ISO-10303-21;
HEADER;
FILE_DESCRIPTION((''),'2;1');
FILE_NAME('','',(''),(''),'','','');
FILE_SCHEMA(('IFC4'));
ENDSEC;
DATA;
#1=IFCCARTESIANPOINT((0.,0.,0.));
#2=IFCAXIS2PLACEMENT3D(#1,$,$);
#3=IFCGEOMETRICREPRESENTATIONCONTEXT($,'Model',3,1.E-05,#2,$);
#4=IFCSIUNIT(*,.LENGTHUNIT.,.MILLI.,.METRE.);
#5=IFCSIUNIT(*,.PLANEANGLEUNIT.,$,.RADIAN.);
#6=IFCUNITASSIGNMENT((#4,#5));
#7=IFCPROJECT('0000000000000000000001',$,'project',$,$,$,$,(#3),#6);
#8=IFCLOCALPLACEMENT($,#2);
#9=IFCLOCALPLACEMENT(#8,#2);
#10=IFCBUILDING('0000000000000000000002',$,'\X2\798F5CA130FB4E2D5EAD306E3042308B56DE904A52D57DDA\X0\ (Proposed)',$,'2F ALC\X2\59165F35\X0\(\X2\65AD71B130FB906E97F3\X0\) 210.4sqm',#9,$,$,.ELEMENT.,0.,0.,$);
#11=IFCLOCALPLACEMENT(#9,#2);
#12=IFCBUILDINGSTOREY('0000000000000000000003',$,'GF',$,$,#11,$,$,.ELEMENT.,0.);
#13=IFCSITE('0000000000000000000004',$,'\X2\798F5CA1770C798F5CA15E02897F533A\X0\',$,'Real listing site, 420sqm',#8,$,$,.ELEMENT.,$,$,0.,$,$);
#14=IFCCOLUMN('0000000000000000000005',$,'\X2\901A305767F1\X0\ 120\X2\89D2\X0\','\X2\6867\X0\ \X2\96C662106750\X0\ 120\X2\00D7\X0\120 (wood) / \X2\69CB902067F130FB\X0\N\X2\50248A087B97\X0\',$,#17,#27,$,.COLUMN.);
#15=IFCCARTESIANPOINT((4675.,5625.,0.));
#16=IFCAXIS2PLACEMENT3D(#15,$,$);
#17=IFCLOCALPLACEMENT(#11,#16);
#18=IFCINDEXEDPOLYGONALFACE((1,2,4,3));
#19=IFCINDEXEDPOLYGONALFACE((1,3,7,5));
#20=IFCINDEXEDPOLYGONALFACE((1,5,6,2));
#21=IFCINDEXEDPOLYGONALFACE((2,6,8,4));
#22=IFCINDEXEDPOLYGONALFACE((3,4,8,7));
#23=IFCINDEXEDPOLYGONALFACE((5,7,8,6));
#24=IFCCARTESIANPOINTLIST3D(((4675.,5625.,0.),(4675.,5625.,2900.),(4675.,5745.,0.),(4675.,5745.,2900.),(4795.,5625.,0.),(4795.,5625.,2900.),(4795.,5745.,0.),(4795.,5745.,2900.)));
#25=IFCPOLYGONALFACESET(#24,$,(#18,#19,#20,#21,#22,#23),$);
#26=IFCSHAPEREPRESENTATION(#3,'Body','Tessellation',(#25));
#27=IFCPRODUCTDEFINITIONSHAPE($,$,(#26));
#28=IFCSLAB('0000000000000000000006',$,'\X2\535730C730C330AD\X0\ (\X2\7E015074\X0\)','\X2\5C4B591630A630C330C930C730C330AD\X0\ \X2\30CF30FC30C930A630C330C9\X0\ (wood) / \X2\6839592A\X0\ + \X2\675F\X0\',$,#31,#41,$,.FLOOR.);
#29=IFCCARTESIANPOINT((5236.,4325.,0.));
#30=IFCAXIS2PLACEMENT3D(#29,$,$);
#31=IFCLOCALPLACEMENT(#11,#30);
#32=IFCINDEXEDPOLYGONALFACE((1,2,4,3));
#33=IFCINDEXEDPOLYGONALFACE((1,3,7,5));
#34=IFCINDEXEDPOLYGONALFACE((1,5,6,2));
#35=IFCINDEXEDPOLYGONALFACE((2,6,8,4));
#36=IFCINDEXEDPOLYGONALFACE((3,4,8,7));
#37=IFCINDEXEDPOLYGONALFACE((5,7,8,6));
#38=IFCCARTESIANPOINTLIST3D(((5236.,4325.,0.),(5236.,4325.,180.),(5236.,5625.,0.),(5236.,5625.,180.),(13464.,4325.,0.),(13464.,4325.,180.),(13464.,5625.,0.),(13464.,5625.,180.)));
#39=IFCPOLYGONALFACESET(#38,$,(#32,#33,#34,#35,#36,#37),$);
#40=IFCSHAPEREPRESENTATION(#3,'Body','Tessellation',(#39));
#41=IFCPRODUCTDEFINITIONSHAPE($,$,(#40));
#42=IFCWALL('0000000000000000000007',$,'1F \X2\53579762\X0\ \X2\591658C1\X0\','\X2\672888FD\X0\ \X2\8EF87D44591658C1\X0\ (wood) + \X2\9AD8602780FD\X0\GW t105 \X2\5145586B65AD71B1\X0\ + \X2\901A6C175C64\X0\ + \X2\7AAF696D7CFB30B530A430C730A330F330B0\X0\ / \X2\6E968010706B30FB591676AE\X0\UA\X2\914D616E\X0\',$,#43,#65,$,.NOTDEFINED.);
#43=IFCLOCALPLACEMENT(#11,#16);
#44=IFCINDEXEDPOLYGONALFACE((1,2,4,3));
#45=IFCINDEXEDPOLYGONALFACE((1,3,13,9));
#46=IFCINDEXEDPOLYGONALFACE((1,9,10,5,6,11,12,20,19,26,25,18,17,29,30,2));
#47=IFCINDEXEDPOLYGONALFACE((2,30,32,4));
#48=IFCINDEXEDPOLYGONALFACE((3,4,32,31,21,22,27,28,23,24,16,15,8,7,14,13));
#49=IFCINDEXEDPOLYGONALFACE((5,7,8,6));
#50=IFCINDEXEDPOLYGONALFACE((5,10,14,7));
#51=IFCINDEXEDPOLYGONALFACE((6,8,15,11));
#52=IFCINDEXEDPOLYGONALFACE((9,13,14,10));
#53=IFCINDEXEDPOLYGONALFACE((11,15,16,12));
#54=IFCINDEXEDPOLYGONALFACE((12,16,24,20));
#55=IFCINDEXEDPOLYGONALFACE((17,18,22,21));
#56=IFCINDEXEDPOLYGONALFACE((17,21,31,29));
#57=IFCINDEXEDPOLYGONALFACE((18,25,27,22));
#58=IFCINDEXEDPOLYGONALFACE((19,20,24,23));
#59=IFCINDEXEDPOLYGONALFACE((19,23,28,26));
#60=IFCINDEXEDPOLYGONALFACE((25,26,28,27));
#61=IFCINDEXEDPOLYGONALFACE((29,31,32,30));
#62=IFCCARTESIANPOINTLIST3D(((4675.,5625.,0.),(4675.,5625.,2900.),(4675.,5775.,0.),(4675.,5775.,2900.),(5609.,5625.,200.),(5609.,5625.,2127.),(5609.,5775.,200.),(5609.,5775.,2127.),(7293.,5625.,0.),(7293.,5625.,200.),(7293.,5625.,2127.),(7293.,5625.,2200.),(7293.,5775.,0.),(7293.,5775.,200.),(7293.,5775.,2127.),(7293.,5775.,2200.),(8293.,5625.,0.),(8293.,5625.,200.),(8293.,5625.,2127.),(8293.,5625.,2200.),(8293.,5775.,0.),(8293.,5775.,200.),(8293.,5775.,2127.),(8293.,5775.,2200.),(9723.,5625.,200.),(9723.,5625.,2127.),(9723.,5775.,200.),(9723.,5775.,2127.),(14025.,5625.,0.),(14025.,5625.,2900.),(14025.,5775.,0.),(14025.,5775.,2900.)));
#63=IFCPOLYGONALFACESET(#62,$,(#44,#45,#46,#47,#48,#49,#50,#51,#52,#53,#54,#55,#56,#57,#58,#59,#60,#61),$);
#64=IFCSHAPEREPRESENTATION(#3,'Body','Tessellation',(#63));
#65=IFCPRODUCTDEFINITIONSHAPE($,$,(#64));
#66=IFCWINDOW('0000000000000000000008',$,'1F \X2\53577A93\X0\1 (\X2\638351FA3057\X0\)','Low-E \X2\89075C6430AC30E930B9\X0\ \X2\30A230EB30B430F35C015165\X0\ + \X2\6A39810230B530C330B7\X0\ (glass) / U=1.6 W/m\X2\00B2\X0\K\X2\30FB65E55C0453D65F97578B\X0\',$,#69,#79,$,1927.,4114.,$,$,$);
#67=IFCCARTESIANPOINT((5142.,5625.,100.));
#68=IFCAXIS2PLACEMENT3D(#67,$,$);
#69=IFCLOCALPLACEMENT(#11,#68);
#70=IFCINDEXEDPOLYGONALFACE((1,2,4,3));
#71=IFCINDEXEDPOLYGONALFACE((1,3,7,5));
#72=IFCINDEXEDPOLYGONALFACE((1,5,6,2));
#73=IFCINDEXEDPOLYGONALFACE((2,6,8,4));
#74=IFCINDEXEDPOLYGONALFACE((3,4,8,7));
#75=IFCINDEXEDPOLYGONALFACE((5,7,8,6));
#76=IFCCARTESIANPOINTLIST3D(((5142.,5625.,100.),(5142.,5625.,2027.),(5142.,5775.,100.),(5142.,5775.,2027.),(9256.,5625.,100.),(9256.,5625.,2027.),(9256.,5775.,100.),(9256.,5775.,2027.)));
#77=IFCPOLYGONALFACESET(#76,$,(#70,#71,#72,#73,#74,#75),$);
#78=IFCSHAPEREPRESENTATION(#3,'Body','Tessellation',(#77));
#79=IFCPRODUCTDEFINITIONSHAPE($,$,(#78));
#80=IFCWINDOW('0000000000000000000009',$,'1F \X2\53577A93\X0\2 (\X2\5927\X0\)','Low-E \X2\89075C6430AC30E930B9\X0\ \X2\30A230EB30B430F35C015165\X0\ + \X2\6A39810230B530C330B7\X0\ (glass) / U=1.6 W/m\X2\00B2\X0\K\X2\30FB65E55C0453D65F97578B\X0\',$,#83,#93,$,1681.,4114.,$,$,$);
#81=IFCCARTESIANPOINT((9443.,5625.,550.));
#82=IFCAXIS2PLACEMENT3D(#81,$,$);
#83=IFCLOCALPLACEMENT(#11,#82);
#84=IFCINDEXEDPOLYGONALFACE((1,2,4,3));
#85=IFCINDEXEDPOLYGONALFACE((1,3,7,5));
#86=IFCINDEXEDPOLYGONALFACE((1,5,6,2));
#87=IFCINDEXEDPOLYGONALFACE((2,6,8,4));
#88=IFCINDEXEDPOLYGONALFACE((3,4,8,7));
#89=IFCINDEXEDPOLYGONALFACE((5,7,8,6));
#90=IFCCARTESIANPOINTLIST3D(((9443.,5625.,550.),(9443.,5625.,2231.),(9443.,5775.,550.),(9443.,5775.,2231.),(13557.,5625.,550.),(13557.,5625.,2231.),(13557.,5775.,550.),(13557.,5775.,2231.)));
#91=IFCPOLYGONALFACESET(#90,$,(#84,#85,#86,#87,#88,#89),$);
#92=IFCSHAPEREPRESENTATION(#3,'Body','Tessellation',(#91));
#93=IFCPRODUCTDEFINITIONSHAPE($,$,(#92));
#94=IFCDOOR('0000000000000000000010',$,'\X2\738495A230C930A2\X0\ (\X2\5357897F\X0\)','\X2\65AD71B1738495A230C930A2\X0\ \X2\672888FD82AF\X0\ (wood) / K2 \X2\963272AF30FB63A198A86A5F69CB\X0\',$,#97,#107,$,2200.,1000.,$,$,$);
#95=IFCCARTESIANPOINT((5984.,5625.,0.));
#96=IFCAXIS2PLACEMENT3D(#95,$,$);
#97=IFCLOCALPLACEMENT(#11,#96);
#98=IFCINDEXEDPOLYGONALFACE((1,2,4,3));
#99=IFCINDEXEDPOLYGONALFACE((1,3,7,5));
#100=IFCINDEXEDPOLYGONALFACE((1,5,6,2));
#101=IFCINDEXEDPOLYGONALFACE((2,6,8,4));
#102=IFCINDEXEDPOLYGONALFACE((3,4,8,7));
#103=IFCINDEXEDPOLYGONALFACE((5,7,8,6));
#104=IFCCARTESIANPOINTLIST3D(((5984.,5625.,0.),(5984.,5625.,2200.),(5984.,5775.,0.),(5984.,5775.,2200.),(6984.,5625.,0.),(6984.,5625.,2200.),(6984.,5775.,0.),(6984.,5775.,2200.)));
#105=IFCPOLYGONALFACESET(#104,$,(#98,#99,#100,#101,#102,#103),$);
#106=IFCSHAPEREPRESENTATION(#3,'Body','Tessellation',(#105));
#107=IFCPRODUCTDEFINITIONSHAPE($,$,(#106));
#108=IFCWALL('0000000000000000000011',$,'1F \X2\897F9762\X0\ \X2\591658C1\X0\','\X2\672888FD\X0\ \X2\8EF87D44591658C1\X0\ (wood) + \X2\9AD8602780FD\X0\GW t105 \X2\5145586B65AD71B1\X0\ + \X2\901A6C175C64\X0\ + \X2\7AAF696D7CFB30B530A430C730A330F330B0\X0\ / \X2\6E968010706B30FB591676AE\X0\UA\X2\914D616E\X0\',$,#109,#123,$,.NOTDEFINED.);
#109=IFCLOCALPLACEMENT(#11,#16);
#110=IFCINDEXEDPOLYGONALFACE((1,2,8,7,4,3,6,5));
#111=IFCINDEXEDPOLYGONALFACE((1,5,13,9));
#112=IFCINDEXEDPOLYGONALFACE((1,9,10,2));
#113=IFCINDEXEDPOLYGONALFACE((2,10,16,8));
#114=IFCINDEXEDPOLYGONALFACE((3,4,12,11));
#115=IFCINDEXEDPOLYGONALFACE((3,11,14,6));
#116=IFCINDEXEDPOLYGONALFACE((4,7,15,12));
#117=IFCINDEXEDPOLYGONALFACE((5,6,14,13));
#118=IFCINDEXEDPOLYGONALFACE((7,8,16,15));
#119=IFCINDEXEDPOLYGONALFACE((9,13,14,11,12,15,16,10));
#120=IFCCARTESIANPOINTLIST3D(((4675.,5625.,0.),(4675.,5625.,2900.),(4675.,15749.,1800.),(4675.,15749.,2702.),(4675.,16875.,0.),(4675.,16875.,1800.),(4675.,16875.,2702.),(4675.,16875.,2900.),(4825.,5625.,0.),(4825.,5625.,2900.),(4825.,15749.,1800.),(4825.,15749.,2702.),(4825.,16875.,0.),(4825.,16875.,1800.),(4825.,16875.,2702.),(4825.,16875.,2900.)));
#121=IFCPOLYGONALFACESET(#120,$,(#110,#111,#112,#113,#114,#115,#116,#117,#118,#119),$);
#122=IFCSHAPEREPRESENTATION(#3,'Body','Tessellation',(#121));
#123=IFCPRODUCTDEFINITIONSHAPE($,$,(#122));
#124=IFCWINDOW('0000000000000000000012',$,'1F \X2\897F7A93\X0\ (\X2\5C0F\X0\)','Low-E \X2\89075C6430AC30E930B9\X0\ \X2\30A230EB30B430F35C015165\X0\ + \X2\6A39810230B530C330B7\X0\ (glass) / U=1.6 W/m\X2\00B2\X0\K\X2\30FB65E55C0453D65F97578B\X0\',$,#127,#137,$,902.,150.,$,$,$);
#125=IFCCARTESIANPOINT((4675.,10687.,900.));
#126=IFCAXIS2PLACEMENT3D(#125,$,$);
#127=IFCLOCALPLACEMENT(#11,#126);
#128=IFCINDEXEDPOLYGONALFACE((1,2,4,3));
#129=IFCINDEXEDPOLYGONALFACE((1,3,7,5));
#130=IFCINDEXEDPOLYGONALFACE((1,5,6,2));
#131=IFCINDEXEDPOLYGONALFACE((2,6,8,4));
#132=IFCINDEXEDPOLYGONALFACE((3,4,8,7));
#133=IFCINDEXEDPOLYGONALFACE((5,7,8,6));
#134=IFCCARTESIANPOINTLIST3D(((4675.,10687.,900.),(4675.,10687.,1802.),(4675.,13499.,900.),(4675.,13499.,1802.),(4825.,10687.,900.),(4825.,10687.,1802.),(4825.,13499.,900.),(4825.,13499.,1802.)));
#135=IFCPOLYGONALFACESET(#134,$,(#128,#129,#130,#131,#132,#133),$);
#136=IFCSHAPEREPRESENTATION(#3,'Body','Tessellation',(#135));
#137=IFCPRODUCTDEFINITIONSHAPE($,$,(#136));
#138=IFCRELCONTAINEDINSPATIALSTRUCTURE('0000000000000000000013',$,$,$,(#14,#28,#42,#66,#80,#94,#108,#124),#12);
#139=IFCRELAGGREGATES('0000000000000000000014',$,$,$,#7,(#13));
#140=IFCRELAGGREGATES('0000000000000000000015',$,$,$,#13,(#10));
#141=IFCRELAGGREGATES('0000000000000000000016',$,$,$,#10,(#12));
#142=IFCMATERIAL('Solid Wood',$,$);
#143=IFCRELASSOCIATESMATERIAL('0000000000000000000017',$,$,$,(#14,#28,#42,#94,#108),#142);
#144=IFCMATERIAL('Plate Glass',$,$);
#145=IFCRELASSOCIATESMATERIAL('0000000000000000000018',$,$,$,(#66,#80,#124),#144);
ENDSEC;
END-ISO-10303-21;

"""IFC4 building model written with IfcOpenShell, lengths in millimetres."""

from ifc_helpers import new_model, si_unit, frame, frame_2d, origin, place, context, project, spatial, rectangle, extrude, material, element, fill, save


model = new_model("IFC4")

# Units and contexts
model_context = context("Model", 3, precision=1e-05, world=origin())
ifc_project = project(units=[si_unit("LENGTHUNIT", "METRE", prefix="MILLI"), si_unit("PLANEANGLEUNIT", "RADIAN")], contexts=[model_context])

# Site, building, storey
site_placement = place(None, origin())
site = spatial("IfcSite", under=ifc_project, at=site_placement, Name="福岡県福岡市西区", ObjectType="Real listing site, 420sqm", CompositionType="ELEMENT", RefElevation=0.0)
building_placement = place(site_placement, origin())
building = spatial("IfcBuilding", under=site, at=building_placement, Name="福岡・中庭のある回遊動線 (Proposed)", ObjectType="2F ALC外張(断熱・遮音) 210.4sqm", CompositionType="ELEMENT", ElevationOfRefHeight=0.0, ElevationOfTerrain=0.0)
storey_placement = place(building_placement, origin())
storey = spatial("IfcBuildingStorey", under=building, at=storey_placement, Name="GF", CompositionType="ELEMENT", Elevation=0.0)

# Column
ifc_material_1 = material(Name="Solid Wood")
column_placement = place(storey_placement, frame((4675.0, 5625.0, 0.0)))
element("IfcColumn", 1, at=column_placement, inside=storey, material=ifc_material_1, Name="通し柱 120角", Description="桧 集成材 120×120 (wood) / 構造柱・N値計算", PredefinedType="COLUMN", context=model_context, shape_type="SweptSolid", body=[
    extrude(rectangle(XDim=120.0, YDim=120.0, at=frame_2d((60.0, 60.0))), frame((4675.0, 5625.0, 0.0)), (0.0, 0.0, 1.0), 2900.0),
])

# Slab
slab_1_placement = place(storey_placement, frame((5236.0, 4325.0, 0.0)))
element("IfcSlab", 2, at=slab_1_placement, inside=storey, material=ifc_material_1, Name="南デッキ (縁側)", Description="屋外ウッドデッキ ハードウッド (wood) / 根太 + 束", PredefinedType="FLOOR", context=model_context, shape_type="SweptSolid", body=[
    extrude(rectangle(XDim=8228.0, YDim=1300.0, at=frame_2d((4114.0, 650.0))), frame((5236.0, 4325.0, 0.0)), (0.0, 0.0, 1.0), 180.0),
])

# Wall, openings, windows, door
wall_1_placement = place(storey_placement, frame((4675.0, 5625.0, 0.0)))
wall_1 = element("IfcWall", 3, at=wall_1_placement, inside=storey, material=ifc_material_1, Name="1F 南面 外壁", Description="木製 軸組外壁 (wood) + 高性能GW t105 充填断熱 + 通気層 + 窯業系サイディング / 準耐火・外皮UA配慮", PredefinedType="NOTDEFINED", context=model_context, shape_type="SweptSolid", body=[
    extrude(rectangle(XDim=9350.0, YDim=150.0, at=frame_2d((4675.0, 75.0))), frame((4675.0, 5625.0, 0.0)), (0.0, 0.0, 1.0), 2900.0),
])
opening_1_placement = place(storey_placement, frame((5142.0, 5625.0, 100.0)))
opening_1 = element("IfcOpeningElement", 4, at=opening_1_placement, cuts=wall_1, PredefinedType="NOTDEFINED", context=model_context, shape_type="SweptSolid", body=[
    extrude(rectangle(XDim=4114.0, YDim=150.0, at=frame_2d((2057.0, 75.0))), frame((5142.0, 5625.0, 100.0)), (0.0, 0.0, 1.0), 1927.0),
])
opening_2_placement = place(storey_placement, frame((9443.0, 5625.0, 550.0)))
opening_2 = element("IfcOpeningElement", 5, at=opening_2_placement, cuts=wall_1, PredefinedType="NOTDEFINED", context=model_context, shape_type="SweptSolid", body=[
    extrude(rectangle(XDim=4114.0, YDim=150.0, at=frame_2d((2057.0, 75.0))), frame((9443.0, 5625.0, 550.0)), (0.0, 0.0, 1.0), 1681.0),
])
opening_3_placement = place(storey_placement, frame((5984.0, 5625.0, 0.0)))
opening_3 = element("IfcOpeningElement", 6, at=opening_3_placement, cuts=wall_1, PredefinedType="NOTDEFINED", context=model_context, shape_type="SweptSolid", body=[
    extrude(rectangle(XDim=1000.0, YDim=150.0, at=frame_2d((500.0, 75.0))), frame((5984.0, 5625.0, 0.0)), (0.0, 0.0, 1.0), 2200.0),
])
ifc_material_2 = material(Name="Plate Glass")
window_1_placement = place(storey_placement, frame((5142.0, 5625.0, 100.0)))
window_1 = element("IfcWindow", 7, at=window_1_placement, inside=storey, material=ifc_material_2, Name="1F 南窓1 (掃出し)", Description="Low-E 複層ガラス アルゴン封入 + 樹脂サッシ (glass) / U=1.6 W/m²K・日射取得型", OverallHeight=1927.0, OverallWidth=4114.0, context=model_context, shape_type="SweptSolid", body=[
    extrude(rectangle(XDim=4114.0, YDim=150.0, at=frame_2d((2057.0, 75.0))), frame((5142.0, 5625.0, 100.0)), (0.0, 0.0, 1.0), 1927.0),
])
fill(opening_1, window_1)
window_2_placement = place(storey_placement, frame((9443.0, 5625.0, 550.0)))
window_2 = element("IfcWindow", 8, at=window_2_placement, inside=storey, material=ifc_material_2, Name="1F 南窓2 (大)", Description="Low-E 複層ガラス アルゴン封入 + 樹脂サッシ (glass) / U=1.6 W/m²K・日射取得型", OverallHeight=1681.0, OverallWidth=4114.0, context=model_context, shape_type="SweptSolid", body=[
    extrude(rectangle(XDim=4114.0, YDim=150.0, at=frame_2d((2057.0, 75.0))), frame((9443.0, 5625.0, 550.0)), (0.0, 0.0, 1.0), 1681.0),
])
fill(opening_2, window_2)
door_placement = place(storey_placement, frame((5984.0, 5625.0, 0.0)))
door = element("IfcDoor", 9, at=door_placement, inside=storey, material=ifc_material_1, Name="玄関ドア (南西)", Description="断熱玄関ドア 木製芯 (wood) / K2 防犯・採風機構", OverallHeight=2200.0, OverallWidth=1000.0, context=model_context, shape_type="SweptSolid", body=[
    extrude(rectangle(XDim=1000.0, YDim=150.0, at=frame_2d((500.0, 75.0))), frame((5984.0, 5625.0, 0.0)), (0.0, 0.0, 1.0), 2200.0),
])
fill(opening_3, door)

# Wall, opening, window
wall_2_placement = place(storey_placement, frame((4675.0, 5625.0, 0.0)))
wall_2 = element("IfcWall", 10, at=wall_2_placement, inside=storey, material=ifc_material_1, Name="1F 西面 外壁", Description="木製 軸組外壁 (wood) + 高性能GW t105 充填断熱 + 通気層 + 窯業系サイディング / 準耐火・外皮UA配慮", PredefinedType="NOTDEFINED", context=model_context, shape_type="SweptSolid", body=[
    extrude(rectangle(XDim=150.0, YDim=11250.0, at=frame_2d((75.0, 5625.0))), frame((4675.0, 5625.0, 0.0)), (0.0, 0.0, 1.0), 2900.0),
])
opening_4_placement = place(storey_placement, frame((4675.0, 10687.0, 900.0)))
opening_4 = element("IfcOpeningElement", 11, at=opening_4_placement, cuts=wall_2, PredefinedType="NOTDEFINED", context=model_context, shape_type="SweptSolid", body=[
    extrude(rectangle(XDim=150.0, YDim=2812.0, at=frame_2d((75.0, 1406.0))), frame((4675.0, 10687.0, 900.0)), (0.0, 0.0, 1.0), 902.0),
])
window_3_placement = place(storey_placement, frame((4675.0, 10687.0, 900.0)))
window_3 = element("IfcWindow", 12, at=window_3_placement, inside=storey, material=ifc_material_2, Name="1F 西窓 (小)", Description="Low-E 複層ガラス アルゴン封入 + 樹脂サッシ (glass) / U=1.6 W/m²K・日射取得型", OverallHeight=902.0, OverallWidth=150.0, context=model_context, shape_type="SweptSolid", body=[
    extrude(rectangle(XDim=150.0, YDim=2812.0, at=frame_2d((75.0, 1406.0))), frame((4675.0, 10687.0, 900.0)), (0.0, 0.0, 1.0), 902.0),
])
fill(opening_4, window_3)

save(model, "model.ifc")
